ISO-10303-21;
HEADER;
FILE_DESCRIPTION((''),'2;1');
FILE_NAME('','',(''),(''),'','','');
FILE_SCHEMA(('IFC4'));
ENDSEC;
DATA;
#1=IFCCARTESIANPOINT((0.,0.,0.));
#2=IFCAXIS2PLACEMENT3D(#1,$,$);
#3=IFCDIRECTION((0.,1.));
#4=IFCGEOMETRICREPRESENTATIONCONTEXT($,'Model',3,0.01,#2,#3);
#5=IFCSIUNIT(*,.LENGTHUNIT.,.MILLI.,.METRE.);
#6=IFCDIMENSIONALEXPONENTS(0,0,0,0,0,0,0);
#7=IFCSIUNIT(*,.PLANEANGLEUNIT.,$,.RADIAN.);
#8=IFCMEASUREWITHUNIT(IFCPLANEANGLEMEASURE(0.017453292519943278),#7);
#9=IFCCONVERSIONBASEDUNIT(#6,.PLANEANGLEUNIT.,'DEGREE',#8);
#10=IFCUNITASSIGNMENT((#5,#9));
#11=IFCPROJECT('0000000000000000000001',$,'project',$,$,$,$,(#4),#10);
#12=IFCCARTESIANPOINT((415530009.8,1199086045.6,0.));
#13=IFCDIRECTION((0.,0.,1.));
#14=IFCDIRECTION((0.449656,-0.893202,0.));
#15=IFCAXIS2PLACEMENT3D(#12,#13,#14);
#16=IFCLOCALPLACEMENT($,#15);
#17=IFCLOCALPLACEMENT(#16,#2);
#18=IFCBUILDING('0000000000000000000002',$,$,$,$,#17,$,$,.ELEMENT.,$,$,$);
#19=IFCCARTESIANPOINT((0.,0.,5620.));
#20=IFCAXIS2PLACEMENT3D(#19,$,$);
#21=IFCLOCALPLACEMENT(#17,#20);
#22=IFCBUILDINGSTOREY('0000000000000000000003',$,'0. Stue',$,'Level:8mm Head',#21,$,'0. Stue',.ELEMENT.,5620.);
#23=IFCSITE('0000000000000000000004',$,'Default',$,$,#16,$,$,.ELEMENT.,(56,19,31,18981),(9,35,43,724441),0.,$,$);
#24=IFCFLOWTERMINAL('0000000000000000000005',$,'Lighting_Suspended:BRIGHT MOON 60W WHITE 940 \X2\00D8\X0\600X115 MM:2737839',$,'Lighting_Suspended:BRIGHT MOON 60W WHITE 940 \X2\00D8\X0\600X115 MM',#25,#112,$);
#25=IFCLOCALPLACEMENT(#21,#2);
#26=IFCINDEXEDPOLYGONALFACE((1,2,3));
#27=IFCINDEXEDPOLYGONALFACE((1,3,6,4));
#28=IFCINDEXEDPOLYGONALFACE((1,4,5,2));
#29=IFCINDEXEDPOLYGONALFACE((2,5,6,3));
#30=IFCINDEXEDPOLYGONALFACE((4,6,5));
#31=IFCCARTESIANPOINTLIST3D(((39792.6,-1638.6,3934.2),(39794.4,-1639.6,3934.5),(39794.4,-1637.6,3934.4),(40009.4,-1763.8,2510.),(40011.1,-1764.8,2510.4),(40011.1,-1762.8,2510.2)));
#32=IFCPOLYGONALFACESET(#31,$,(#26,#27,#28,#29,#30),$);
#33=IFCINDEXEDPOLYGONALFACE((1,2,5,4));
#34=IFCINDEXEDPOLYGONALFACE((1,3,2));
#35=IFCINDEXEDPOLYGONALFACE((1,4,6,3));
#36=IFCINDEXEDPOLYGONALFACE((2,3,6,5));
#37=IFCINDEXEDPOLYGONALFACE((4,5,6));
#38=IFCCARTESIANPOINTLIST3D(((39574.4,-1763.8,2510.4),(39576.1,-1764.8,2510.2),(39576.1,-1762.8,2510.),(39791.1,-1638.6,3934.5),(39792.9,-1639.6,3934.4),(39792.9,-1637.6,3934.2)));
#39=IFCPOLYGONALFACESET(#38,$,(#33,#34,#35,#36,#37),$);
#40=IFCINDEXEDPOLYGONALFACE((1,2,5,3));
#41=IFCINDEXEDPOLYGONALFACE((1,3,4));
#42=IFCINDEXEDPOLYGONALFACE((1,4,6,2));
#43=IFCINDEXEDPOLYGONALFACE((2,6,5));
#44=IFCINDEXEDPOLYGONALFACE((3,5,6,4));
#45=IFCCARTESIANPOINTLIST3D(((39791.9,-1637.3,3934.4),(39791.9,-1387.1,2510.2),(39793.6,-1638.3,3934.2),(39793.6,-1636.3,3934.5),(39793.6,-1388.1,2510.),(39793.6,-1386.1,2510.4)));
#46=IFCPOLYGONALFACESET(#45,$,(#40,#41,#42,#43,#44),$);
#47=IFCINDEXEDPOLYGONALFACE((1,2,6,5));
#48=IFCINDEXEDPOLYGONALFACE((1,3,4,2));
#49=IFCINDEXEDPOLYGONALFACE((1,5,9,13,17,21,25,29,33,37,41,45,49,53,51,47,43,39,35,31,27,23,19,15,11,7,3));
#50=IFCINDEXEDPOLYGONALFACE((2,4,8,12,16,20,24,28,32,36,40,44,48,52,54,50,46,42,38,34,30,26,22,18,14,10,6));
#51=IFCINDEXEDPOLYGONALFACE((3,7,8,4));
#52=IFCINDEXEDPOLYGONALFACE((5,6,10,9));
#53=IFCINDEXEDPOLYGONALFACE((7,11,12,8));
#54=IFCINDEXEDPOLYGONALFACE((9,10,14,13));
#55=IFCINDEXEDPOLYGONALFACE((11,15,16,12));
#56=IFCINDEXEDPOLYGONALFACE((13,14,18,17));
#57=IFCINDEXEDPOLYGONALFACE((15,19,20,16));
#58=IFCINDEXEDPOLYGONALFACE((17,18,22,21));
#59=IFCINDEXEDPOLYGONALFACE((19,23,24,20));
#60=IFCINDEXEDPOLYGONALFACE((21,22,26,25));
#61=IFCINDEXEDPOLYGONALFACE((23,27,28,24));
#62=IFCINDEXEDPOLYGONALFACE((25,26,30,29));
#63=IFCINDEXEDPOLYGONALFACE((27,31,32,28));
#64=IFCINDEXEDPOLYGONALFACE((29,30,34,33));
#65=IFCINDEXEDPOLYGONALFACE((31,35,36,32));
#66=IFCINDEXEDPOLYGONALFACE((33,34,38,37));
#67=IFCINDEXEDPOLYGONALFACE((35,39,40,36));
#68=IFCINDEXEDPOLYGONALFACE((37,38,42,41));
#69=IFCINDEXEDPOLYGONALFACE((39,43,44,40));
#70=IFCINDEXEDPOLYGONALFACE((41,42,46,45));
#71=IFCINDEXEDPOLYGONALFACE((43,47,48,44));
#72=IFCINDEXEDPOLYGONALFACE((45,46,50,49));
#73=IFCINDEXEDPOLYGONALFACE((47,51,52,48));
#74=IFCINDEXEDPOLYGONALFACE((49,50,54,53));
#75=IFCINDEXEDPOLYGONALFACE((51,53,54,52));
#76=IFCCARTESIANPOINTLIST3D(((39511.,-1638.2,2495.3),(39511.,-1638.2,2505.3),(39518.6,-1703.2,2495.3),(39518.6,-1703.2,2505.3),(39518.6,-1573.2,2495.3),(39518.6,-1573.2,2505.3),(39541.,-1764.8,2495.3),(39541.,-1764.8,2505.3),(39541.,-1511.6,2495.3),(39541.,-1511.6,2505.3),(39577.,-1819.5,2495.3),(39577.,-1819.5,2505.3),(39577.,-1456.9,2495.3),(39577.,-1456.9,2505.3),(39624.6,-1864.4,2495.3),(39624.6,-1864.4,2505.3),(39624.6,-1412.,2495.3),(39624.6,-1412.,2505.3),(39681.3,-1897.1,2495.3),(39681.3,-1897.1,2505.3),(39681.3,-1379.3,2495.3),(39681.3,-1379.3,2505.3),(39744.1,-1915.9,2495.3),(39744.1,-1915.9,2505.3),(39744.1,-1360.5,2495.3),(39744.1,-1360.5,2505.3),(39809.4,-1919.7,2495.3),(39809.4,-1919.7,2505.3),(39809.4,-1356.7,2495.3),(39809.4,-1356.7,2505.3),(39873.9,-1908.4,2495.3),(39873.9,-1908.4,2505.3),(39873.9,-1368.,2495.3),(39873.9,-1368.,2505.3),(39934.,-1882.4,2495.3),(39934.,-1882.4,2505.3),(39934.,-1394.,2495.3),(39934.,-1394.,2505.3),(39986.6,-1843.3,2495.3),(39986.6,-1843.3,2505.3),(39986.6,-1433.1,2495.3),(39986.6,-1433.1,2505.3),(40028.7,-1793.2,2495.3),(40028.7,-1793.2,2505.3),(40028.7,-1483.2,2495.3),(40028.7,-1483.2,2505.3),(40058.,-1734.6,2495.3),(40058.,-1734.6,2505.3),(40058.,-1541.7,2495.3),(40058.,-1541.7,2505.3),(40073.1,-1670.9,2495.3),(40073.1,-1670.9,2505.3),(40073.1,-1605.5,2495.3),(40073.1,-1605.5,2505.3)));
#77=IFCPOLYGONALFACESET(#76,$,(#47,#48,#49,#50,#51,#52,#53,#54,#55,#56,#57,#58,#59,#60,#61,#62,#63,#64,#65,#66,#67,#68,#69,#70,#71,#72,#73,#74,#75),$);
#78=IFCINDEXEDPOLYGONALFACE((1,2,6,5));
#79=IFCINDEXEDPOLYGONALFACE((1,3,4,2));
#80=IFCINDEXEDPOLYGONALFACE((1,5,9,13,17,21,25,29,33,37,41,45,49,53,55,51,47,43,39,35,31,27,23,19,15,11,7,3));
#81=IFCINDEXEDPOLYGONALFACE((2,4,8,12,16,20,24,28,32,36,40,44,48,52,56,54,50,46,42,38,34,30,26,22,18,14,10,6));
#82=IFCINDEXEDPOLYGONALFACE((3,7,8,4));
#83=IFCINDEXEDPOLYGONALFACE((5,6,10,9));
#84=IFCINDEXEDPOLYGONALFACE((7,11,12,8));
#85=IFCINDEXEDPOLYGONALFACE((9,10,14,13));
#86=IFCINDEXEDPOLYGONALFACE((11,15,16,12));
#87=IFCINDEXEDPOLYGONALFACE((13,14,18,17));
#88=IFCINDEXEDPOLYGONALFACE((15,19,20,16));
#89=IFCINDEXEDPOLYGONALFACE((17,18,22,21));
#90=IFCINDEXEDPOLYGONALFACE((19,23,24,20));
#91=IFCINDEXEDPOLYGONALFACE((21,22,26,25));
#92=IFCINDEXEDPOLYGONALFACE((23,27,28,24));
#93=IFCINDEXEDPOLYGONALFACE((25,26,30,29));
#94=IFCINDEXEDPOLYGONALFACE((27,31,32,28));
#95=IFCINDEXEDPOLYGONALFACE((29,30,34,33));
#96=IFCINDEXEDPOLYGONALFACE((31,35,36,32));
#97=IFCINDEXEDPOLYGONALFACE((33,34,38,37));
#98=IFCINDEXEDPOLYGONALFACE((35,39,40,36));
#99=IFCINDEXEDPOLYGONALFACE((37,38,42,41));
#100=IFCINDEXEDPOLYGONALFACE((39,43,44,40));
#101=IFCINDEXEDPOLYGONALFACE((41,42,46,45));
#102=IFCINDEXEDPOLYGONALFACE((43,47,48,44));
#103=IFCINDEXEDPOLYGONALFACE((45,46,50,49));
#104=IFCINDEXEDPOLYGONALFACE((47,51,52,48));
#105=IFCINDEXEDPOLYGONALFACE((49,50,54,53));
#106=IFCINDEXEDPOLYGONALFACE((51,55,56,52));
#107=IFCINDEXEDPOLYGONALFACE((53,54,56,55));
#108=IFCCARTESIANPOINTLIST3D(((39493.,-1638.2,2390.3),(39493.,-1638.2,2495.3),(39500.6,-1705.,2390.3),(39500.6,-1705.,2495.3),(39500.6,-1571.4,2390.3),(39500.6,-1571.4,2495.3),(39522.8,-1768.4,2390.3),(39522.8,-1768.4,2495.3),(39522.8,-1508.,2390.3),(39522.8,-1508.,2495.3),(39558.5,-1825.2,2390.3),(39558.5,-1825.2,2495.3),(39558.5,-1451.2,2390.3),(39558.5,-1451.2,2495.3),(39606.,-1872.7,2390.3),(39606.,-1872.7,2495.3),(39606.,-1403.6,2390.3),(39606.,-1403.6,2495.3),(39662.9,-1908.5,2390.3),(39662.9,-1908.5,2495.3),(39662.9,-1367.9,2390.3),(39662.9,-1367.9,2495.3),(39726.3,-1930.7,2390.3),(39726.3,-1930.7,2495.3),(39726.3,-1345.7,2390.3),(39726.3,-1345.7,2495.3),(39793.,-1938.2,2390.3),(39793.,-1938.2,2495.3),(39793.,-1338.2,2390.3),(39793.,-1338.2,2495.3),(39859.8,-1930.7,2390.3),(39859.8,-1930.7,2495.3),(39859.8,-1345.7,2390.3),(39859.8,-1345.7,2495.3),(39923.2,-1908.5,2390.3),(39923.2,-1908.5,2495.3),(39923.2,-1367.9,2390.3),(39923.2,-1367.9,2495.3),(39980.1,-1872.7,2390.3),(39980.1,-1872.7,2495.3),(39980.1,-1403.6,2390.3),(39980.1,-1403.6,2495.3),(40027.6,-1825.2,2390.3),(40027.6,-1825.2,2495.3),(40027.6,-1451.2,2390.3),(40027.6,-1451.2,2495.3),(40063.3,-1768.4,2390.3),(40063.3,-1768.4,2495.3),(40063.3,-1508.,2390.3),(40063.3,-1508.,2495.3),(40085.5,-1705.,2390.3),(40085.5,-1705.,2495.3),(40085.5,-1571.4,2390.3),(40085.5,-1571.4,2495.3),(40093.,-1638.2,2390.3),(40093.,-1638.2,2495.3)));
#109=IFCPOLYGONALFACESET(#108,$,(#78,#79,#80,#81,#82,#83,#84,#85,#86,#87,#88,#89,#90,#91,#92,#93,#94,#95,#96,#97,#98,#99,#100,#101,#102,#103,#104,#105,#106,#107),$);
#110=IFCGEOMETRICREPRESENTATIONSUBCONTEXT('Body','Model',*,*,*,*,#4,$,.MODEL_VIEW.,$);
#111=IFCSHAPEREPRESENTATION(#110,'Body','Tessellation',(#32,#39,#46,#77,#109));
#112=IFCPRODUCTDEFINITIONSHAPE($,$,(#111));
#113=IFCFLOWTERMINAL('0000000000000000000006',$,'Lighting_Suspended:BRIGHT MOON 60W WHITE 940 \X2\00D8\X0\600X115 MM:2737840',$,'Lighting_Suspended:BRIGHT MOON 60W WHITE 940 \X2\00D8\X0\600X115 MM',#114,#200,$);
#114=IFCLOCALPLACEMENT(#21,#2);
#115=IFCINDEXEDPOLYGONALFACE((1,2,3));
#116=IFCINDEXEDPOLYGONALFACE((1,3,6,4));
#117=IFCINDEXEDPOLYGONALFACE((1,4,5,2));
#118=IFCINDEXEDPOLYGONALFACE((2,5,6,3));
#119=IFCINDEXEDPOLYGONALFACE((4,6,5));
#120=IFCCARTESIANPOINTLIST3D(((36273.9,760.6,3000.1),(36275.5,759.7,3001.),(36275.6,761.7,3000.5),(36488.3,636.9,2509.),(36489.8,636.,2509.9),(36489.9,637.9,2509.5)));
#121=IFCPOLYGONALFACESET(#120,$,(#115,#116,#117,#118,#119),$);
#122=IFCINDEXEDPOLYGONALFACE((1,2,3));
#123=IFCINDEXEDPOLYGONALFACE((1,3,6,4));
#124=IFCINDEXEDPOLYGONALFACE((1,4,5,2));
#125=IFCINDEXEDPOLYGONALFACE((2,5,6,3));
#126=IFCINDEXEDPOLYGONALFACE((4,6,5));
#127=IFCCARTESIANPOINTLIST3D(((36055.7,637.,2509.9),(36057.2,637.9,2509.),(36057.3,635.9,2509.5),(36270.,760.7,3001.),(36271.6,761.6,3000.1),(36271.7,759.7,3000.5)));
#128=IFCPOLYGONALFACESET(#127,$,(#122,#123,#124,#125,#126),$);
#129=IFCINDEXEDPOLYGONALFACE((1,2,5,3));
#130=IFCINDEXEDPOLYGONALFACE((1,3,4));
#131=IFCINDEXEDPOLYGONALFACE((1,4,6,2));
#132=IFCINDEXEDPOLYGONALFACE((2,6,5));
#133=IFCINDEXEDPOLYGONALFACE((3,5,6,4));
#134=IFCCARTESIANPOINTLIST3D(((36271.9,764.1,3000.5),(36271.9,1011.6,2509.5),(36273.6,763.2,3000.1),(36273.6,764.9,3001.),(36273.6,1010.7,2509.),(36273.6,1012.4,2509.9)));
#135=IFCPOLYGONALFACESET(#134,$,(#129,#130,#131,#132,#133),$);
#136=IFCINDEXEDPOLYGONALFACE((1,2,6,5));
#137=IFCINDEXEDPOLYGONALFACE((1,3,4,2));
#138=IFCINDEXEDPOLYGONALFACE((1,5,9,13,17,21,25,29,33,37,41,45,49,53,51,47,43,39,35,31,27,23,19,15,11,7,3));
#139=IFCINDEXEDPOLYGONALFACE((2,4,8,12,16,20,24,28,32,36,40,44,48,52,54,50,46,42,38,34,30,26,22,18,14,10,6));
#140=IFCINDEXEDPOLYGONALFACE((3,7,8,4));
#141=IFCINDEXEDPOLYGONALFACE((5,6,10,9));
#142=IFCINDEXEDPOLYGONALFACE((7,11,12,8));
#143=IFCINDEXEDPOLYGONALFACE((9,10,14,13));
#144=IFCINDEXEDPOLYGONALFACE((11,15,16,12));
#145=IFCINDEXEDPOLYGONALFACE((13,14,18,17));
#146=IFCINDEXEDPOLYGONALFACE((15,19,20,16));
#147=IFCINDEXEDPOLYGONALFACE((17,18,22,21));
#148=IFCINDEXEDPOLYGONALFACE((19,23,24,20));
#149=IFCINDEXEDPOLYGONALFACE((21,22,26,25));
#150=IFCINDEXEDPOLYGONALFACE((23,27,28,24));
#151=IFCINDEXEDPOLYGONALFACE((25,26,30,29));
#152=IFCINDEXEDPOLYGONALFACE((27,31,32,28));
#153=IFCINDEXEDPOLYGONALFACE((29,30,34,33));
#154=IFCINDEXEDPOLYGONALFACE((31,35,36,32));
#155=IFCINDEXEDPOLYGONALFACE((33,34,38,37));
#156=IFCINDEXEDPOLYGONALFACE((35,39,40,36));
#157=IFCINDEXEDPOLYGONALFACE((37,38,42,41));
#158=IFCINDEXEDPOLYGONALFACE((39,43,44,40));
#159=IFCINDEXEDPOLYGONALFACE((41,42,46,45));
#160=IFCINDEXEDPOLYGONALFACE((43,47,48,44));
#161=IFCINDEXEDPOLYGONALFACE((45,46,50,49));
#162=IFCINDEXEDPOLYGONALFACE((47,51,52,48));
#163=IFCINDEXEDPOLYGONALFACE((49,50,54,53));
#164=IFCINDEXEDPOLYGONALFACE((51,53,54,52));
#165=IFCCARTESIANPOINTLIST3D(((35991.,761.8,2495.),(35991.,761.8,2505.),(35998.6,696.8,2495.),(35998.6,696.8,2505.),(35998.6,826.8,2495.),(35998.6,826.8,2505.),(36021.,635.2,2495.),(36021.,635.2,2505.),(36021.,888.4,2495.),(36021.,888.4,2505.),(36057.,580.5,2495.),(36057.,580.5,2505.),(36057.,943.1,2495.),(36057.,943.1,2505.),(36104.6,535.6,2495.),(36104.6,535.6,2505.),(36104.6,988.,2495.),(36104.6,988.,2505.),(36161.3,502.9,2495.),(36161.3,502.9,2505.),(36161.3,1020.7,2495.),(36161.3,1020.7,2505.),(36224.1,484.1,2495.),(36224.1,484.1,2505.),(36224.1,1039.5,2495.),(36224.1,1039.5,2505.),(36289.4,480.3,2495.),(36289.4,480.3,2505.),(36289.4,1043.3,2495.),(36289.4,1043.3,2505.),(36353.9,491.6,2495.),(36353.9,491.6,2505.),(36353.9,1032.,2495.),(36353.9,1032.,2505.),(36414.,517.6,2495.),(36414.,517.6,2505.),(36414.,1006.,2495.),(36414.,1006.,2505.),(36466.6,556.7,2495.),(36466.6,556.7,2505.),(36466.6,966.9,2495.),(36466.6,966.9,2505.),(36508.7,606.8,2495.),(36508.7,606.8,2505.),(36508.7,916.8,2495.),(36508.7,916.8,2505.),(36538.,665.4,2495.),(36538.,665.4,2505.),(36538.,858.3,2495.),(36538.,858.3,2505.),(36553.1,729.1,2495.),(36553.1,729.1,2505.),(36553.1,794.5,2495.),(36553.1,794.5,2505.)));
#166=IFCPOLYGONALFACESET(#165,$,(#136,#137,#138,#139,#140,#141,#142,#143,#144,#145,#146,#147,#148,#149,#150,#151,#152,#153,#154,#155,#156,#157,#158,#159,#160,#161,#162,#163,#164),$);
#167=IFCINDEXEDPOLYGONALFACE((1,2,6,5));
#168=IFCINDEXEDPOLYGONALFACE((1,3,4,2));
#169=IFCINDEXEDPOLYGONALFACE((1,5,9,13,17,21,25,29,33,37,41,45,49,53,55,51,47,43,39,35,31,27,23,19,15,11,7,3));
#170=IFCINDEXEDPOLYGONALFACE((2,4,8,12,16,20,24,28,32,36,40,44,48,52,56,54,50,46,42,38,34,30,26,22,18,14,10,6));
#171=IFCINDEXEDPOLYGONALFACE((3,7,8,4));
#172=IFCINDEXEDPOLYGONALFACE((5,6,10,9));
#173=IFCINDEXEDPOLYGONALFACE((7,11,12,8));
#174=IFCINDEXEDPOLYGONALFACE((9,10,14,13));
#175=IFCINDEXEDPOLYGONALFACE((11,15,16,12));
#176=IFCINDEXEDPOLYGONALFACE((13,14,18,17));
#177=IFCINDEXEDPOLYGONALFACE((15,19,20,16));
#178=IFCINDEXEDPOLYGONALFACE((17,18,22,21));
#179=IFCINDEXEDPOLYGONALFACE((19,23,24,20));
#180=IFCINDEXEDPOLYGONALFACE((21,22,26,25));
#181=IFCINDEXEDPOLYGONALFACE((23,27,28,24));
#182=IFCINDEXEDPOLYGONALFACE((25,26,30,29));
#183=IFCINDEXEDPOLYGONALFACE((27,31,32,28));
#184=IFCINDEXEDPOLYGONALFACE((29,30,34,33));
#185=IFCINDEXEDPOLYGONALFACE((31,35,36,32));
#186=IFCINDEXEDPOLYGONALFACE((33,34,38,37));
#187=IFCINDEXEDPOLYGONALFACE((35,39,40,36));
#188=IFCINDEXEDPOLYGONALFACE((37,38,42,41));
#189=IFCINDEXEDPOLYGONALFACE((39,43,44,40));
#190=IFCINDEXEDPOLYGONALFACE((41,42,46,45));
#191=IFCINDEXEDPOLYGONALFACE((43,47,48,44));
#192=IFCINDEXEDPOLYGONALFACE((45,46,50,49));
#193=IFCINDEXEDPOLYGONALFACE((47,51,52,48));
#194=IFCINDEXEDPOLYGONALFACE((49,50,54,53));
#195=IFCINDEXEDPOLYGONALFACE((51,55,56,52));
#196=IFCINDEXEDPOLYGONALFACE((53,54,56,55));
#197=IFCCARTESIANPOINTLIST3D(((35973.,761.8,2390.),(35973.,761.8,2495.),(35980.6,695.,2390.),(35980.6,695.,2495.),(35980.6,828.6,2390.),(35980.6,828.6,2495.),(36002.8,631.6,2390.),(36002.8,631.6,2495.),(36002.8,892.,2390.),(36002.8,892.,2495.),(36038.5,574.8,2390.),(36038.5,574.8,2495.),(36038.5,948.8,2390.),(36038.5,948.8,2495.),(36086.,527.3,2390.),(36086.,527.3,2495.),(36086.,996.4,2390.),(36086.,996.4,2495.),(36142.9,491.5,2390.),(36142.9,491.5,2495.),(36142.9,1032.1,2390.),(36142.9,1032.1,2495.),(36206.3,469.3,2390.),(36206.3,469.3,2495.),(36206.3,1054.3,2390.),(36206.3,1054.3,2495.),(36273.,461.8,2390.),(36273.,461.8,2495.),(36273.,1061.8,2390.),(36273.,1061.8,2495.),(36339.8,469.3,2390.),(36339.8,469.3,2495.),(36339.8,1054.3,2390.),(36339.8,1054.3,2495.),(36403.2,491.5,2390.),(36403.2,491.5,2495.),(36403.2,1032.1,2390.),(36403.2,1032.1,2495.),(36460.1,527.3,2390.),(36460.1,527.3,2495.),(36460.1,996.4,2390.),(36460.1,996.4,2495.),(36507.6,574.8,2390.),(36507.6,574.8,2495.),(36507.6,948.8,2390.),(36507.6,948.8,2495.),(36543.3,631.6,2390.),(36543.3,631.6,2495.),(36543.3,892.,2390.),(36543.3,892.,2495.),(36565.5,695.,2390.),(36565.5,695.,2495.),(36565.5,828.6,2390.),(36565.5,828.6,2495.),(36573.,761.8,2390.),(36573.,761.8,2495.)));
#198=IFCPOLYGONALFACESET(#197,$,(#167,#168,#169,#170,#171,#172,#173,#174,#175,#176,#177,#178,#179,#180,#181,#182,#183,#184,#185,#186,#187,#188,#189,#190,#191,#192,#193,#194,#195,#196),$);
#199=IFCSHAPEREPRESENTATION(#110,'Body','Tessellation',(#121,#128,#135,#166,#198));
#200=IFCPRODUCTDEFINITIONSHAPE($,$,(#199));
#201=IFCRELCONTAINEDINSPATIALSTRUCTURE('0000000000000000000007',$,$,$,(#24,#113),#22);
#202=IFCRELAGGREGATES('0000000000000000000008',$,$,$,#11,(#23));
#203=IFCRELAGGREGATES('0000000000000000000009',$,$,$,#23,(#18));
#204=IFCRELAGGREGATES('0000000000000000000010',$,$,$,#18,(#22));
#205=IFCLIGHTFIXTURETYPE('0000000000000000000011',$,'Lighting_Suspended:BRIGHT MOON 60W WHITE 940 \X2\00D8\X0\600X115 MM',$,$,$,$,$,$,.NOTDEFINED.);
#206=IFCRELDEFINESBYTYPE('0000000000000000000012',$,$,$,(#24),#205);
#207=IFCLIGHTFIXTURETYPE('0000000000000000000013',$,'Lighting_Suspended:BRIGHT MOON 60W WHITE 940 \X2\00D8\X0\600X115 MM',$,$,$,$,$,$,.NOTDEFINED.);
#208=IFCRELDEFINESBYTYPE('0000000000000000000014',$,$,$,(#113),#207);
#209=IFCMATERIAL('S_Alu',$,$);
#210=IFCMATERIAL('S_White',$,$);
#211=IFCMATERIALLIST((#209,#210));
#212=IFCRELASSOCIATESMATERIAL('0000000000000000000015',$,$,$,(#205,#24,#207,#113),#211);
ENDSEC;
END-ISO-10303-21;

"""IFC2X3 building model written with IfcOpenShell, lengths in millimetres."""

from ifc_helpers import new_model, entity, si_unit, converted_unit, direction, frame, frame_2d, origin, place, context, subcontext, project, spatial, polyline, circle, outline, extrude, source, transform, mapped, material, material_list, type_object, type_shapes, element, save


model = new_model("IFC2X3")

# Units and contexts
model_context = context("Model", 3, precision=0.01, world=origin(), true_north=direction((0.0, 1.0)))
body_context = subcontext(model_context, "Body", "Model", "MODEL_VIEW")
ifc_project = project(units=[si_unit("LENGTHUNIT", "METRE", prefix="MILLI"), converted_unit("PLANEANGLEUNIT", "DEGREE", entity("IfcPlaneAngleMeasure", 0.017453292519943278), si_unit("PLANEANGLEUNIT", "RADIAN"), dimensions=[0, 0, 0, 0, 0, 0, 0])], contexts=[model_context])

# Site, building, storey
site_placement = place(None, frame((415530009.8, 1199086045.6, 0.0), z_axis=(0.0, 0.0, 1.0), x_axis=(0.449656, -0.893202, 0.0)))
site = spatial("IfcSite", under=ifc_project, at=site_placement, Name="Default", CompositionType="ELEMENT", RefLatitude=(56, 19, 31, 18981), RefLongitude=(9, 35, 43, 724441), RefElevation=0.0)
building_placement = place(site_placement, origin())
building = spatial("IfcBuilding", under=site, at=building_placement, CompositionType="ELEMENT")
storey_placement = place(building_placement, frame((0.0, 0.0, 5620.0)))
storey = spatial("IfcBuildingStorey", under=building, at=storey_placement, Name="0. Stue", ObjectType="Level:8mm Head", LongName="0. Stue", CompositionType="ELEMENT", Elevation=5620.0)

# Flow terminals
ifc_material_1 = material(Name="S_White")
ifc_material_2 = material(Name="S_Alu")
ifc_material_list = material_list([ifc_material_2, ifc_material_1])
light_fixture_type_1 = type_object("IfcLightFixtureType", Name="Lighting_Suspended:BRIGHT MOON 60W WHITE 940 Ø600X115 MM", PredefinedType="NOTDEFINED", material=ifc_material_list)
shared_shape_1 = source(origin(), body_context, "Body", "SweptSolid", [
    extrude(outline(polyline([(-1.0, -0.6), (1.0, -0.6), (0.0, 1.2), (-1.0, -0.6)])), frame((-217.5, 125.6, -1429.1), z_axis=(0.149892, -0.08654, 0.984908), x_axis=(-0.852955, 0.492454, 0.17308)), (0.0, 0.0, 1.0), 1446.0),
    extrude(outline(polyline([(-1.0, -0.6), (1.0, -0.6), (0.0, 1.2), (-1.0, -0.6)])), frame((217.5, 125.6, -1429.1), z_axis=(-0.149892, -0.08654, 0.984908), x_axis=(0.852955, 0.492454, 0.17308)), (0.0, 0.0, 1.0), 1446.0),
    extrude(outline(polyline([(-1.0, -0.6), (1.0, -0.6), (0.0, 1.2), (-1.0, -0.6)])), frame((0.0, -251.1, -1429.1), z_axis=(0.0, 0.17308, 0.984908), x_axis=(0.0, -0.984908, 0.17308)), (0.0, 0.0, 1.0), 1446.0),
    extrude(circle(Radius=282.0, at=frame_2d((0.0, 0.0), x_axis=(1.0, 0.0))), frame((0.0, 0.0, -1444.0)), (0.0, 0.0, 1.0), 10.0),
    extrude(circle(Radius=300.0, at=frame_2d((0.0, 0.0), x_axis=(1.0, 0.0))), frame((0.0, 0.0, -1549.0)), (0.0, 0.0, 1.0), 105.0),
])
type_shapes(light_fixture_type_1, [shared_shape_1])
for number, where, z_axis, x_axis, name in (
    (1, (39793.0, -1638.2, 3939.3), (0.0, 0.0, 1.0), (-1.0, 0.0, 0.0), "Lighting_Suspended:BRIGHT MOON 60W WHITE 940 Ø600X115 MM:2737839"),
):
    element("IfcFlowTerminal", number, at=place(storey_placement, frame(where, z_axis=z_axis, x_axis=x_axis)), inside=storey, type_object=light_fixture_type_1, material=ifc_material_list, Name=name, ObjectType="Lighting_Suspended:BRIGHT MOON 60W WHITE 940 Ø600X115 MM", context=body_context, shape_type="MappedRepresentation", body=[
        mapped(shared_shape_1, transform((0.0, 0.0, 0.0), scale=1.0)),
    ])
light_fixture_type_2 = type_object("IfcLightFixtureType", Name="Lighting_Suspended:BRIGHT MOON 60W WHITE 940 Ø600X115 MM", PredefinedType="NOTDEFINED", material=ifc_material_list)
shared_shape_2 = source(origin(), body_context, "Body", "SweptSolid", [
    extrude(outline(polyline([(-1.0, -0.6), (1.0, -0.6), (0.0, 1.2), (-1.0, -0.6)])), frame((-216.3, 124.9, -495.5), z_axis=(0.389771, -0.225034, 0.892994), x_axis=(-0.773355, 0.446497, 0.450069)), (0.0, 0.0, 1.0), 549.9),
    extrude(outline(polyline([(-1.0, -0.6), (1.0, -0.6), (0.0, 1.2), (-1.0, -0.6)])), frame((216.3, 124.9, -495.5), z_axis=(-0.389771, -0.225034, 0.892994), x_axis=(0.773355, 0.446497, 0.450069)), (0.0, 0.0, 1.0), 549.9),
    extrude(outline(polyline([(-1.0, -0.6), (1.0, -0.6), (0.0, 1.2), (-1.0, -0.6)])), frame((0.0, -249.7, -495.5), z_axis=(0.0, 0.450069, 0.892994), x_axis=(0.0, -0.892994, 0.450069)), (0.0, 0.0, 1.0), 549.9),
    extrude(circle(Radius=282.0, at=frame_2d((0.0, 0.0), x_axis=(1.0, 0.0))), frame((0.0, 0.0, -510.0)), (0.0, 0.0, 1.0), 10.0),
    extrude(circle(Radius=300.0, at=frame_2d((0.0, 0.0), x_axis=(1.0, 0.0))), frame((0.0, 0.0, -615.0)), (0.0, 0.0, 1.0), 105.0),
])
type_shapes(light_fixture_type_2, [shared_shape_2])
for number, where, z_axis, x_axis, name in (
    (2, (36273.0, 761.8, 3005.0), (0.0, 0.0, 1.0), (-1.0, 0.0, 0.0), "Lighting_Suspended:BRIGHT MOON 60W WHITE 940 Ø600X115 MM:2737840"),
):
    element("IfcFlowTerminal", number, at=place(storey_placement, frame(where, z_axis=z_axis, x_axis=x_axis)), inside=storey, type_object=light_fixture_type_2, material=ifc_material_list, Name=name, ObjectType="Lighting_Suspended:BRIGHT MOON 60W WHITE 940 Ø600X115 MM", context=body_context, shape_type="MappedRepresentation", body=[
        mapped(shared_shape_2, transform((0.0, 0.0, 0.0), scale=1.0)),
    ])

save(model, "model.ifc")
